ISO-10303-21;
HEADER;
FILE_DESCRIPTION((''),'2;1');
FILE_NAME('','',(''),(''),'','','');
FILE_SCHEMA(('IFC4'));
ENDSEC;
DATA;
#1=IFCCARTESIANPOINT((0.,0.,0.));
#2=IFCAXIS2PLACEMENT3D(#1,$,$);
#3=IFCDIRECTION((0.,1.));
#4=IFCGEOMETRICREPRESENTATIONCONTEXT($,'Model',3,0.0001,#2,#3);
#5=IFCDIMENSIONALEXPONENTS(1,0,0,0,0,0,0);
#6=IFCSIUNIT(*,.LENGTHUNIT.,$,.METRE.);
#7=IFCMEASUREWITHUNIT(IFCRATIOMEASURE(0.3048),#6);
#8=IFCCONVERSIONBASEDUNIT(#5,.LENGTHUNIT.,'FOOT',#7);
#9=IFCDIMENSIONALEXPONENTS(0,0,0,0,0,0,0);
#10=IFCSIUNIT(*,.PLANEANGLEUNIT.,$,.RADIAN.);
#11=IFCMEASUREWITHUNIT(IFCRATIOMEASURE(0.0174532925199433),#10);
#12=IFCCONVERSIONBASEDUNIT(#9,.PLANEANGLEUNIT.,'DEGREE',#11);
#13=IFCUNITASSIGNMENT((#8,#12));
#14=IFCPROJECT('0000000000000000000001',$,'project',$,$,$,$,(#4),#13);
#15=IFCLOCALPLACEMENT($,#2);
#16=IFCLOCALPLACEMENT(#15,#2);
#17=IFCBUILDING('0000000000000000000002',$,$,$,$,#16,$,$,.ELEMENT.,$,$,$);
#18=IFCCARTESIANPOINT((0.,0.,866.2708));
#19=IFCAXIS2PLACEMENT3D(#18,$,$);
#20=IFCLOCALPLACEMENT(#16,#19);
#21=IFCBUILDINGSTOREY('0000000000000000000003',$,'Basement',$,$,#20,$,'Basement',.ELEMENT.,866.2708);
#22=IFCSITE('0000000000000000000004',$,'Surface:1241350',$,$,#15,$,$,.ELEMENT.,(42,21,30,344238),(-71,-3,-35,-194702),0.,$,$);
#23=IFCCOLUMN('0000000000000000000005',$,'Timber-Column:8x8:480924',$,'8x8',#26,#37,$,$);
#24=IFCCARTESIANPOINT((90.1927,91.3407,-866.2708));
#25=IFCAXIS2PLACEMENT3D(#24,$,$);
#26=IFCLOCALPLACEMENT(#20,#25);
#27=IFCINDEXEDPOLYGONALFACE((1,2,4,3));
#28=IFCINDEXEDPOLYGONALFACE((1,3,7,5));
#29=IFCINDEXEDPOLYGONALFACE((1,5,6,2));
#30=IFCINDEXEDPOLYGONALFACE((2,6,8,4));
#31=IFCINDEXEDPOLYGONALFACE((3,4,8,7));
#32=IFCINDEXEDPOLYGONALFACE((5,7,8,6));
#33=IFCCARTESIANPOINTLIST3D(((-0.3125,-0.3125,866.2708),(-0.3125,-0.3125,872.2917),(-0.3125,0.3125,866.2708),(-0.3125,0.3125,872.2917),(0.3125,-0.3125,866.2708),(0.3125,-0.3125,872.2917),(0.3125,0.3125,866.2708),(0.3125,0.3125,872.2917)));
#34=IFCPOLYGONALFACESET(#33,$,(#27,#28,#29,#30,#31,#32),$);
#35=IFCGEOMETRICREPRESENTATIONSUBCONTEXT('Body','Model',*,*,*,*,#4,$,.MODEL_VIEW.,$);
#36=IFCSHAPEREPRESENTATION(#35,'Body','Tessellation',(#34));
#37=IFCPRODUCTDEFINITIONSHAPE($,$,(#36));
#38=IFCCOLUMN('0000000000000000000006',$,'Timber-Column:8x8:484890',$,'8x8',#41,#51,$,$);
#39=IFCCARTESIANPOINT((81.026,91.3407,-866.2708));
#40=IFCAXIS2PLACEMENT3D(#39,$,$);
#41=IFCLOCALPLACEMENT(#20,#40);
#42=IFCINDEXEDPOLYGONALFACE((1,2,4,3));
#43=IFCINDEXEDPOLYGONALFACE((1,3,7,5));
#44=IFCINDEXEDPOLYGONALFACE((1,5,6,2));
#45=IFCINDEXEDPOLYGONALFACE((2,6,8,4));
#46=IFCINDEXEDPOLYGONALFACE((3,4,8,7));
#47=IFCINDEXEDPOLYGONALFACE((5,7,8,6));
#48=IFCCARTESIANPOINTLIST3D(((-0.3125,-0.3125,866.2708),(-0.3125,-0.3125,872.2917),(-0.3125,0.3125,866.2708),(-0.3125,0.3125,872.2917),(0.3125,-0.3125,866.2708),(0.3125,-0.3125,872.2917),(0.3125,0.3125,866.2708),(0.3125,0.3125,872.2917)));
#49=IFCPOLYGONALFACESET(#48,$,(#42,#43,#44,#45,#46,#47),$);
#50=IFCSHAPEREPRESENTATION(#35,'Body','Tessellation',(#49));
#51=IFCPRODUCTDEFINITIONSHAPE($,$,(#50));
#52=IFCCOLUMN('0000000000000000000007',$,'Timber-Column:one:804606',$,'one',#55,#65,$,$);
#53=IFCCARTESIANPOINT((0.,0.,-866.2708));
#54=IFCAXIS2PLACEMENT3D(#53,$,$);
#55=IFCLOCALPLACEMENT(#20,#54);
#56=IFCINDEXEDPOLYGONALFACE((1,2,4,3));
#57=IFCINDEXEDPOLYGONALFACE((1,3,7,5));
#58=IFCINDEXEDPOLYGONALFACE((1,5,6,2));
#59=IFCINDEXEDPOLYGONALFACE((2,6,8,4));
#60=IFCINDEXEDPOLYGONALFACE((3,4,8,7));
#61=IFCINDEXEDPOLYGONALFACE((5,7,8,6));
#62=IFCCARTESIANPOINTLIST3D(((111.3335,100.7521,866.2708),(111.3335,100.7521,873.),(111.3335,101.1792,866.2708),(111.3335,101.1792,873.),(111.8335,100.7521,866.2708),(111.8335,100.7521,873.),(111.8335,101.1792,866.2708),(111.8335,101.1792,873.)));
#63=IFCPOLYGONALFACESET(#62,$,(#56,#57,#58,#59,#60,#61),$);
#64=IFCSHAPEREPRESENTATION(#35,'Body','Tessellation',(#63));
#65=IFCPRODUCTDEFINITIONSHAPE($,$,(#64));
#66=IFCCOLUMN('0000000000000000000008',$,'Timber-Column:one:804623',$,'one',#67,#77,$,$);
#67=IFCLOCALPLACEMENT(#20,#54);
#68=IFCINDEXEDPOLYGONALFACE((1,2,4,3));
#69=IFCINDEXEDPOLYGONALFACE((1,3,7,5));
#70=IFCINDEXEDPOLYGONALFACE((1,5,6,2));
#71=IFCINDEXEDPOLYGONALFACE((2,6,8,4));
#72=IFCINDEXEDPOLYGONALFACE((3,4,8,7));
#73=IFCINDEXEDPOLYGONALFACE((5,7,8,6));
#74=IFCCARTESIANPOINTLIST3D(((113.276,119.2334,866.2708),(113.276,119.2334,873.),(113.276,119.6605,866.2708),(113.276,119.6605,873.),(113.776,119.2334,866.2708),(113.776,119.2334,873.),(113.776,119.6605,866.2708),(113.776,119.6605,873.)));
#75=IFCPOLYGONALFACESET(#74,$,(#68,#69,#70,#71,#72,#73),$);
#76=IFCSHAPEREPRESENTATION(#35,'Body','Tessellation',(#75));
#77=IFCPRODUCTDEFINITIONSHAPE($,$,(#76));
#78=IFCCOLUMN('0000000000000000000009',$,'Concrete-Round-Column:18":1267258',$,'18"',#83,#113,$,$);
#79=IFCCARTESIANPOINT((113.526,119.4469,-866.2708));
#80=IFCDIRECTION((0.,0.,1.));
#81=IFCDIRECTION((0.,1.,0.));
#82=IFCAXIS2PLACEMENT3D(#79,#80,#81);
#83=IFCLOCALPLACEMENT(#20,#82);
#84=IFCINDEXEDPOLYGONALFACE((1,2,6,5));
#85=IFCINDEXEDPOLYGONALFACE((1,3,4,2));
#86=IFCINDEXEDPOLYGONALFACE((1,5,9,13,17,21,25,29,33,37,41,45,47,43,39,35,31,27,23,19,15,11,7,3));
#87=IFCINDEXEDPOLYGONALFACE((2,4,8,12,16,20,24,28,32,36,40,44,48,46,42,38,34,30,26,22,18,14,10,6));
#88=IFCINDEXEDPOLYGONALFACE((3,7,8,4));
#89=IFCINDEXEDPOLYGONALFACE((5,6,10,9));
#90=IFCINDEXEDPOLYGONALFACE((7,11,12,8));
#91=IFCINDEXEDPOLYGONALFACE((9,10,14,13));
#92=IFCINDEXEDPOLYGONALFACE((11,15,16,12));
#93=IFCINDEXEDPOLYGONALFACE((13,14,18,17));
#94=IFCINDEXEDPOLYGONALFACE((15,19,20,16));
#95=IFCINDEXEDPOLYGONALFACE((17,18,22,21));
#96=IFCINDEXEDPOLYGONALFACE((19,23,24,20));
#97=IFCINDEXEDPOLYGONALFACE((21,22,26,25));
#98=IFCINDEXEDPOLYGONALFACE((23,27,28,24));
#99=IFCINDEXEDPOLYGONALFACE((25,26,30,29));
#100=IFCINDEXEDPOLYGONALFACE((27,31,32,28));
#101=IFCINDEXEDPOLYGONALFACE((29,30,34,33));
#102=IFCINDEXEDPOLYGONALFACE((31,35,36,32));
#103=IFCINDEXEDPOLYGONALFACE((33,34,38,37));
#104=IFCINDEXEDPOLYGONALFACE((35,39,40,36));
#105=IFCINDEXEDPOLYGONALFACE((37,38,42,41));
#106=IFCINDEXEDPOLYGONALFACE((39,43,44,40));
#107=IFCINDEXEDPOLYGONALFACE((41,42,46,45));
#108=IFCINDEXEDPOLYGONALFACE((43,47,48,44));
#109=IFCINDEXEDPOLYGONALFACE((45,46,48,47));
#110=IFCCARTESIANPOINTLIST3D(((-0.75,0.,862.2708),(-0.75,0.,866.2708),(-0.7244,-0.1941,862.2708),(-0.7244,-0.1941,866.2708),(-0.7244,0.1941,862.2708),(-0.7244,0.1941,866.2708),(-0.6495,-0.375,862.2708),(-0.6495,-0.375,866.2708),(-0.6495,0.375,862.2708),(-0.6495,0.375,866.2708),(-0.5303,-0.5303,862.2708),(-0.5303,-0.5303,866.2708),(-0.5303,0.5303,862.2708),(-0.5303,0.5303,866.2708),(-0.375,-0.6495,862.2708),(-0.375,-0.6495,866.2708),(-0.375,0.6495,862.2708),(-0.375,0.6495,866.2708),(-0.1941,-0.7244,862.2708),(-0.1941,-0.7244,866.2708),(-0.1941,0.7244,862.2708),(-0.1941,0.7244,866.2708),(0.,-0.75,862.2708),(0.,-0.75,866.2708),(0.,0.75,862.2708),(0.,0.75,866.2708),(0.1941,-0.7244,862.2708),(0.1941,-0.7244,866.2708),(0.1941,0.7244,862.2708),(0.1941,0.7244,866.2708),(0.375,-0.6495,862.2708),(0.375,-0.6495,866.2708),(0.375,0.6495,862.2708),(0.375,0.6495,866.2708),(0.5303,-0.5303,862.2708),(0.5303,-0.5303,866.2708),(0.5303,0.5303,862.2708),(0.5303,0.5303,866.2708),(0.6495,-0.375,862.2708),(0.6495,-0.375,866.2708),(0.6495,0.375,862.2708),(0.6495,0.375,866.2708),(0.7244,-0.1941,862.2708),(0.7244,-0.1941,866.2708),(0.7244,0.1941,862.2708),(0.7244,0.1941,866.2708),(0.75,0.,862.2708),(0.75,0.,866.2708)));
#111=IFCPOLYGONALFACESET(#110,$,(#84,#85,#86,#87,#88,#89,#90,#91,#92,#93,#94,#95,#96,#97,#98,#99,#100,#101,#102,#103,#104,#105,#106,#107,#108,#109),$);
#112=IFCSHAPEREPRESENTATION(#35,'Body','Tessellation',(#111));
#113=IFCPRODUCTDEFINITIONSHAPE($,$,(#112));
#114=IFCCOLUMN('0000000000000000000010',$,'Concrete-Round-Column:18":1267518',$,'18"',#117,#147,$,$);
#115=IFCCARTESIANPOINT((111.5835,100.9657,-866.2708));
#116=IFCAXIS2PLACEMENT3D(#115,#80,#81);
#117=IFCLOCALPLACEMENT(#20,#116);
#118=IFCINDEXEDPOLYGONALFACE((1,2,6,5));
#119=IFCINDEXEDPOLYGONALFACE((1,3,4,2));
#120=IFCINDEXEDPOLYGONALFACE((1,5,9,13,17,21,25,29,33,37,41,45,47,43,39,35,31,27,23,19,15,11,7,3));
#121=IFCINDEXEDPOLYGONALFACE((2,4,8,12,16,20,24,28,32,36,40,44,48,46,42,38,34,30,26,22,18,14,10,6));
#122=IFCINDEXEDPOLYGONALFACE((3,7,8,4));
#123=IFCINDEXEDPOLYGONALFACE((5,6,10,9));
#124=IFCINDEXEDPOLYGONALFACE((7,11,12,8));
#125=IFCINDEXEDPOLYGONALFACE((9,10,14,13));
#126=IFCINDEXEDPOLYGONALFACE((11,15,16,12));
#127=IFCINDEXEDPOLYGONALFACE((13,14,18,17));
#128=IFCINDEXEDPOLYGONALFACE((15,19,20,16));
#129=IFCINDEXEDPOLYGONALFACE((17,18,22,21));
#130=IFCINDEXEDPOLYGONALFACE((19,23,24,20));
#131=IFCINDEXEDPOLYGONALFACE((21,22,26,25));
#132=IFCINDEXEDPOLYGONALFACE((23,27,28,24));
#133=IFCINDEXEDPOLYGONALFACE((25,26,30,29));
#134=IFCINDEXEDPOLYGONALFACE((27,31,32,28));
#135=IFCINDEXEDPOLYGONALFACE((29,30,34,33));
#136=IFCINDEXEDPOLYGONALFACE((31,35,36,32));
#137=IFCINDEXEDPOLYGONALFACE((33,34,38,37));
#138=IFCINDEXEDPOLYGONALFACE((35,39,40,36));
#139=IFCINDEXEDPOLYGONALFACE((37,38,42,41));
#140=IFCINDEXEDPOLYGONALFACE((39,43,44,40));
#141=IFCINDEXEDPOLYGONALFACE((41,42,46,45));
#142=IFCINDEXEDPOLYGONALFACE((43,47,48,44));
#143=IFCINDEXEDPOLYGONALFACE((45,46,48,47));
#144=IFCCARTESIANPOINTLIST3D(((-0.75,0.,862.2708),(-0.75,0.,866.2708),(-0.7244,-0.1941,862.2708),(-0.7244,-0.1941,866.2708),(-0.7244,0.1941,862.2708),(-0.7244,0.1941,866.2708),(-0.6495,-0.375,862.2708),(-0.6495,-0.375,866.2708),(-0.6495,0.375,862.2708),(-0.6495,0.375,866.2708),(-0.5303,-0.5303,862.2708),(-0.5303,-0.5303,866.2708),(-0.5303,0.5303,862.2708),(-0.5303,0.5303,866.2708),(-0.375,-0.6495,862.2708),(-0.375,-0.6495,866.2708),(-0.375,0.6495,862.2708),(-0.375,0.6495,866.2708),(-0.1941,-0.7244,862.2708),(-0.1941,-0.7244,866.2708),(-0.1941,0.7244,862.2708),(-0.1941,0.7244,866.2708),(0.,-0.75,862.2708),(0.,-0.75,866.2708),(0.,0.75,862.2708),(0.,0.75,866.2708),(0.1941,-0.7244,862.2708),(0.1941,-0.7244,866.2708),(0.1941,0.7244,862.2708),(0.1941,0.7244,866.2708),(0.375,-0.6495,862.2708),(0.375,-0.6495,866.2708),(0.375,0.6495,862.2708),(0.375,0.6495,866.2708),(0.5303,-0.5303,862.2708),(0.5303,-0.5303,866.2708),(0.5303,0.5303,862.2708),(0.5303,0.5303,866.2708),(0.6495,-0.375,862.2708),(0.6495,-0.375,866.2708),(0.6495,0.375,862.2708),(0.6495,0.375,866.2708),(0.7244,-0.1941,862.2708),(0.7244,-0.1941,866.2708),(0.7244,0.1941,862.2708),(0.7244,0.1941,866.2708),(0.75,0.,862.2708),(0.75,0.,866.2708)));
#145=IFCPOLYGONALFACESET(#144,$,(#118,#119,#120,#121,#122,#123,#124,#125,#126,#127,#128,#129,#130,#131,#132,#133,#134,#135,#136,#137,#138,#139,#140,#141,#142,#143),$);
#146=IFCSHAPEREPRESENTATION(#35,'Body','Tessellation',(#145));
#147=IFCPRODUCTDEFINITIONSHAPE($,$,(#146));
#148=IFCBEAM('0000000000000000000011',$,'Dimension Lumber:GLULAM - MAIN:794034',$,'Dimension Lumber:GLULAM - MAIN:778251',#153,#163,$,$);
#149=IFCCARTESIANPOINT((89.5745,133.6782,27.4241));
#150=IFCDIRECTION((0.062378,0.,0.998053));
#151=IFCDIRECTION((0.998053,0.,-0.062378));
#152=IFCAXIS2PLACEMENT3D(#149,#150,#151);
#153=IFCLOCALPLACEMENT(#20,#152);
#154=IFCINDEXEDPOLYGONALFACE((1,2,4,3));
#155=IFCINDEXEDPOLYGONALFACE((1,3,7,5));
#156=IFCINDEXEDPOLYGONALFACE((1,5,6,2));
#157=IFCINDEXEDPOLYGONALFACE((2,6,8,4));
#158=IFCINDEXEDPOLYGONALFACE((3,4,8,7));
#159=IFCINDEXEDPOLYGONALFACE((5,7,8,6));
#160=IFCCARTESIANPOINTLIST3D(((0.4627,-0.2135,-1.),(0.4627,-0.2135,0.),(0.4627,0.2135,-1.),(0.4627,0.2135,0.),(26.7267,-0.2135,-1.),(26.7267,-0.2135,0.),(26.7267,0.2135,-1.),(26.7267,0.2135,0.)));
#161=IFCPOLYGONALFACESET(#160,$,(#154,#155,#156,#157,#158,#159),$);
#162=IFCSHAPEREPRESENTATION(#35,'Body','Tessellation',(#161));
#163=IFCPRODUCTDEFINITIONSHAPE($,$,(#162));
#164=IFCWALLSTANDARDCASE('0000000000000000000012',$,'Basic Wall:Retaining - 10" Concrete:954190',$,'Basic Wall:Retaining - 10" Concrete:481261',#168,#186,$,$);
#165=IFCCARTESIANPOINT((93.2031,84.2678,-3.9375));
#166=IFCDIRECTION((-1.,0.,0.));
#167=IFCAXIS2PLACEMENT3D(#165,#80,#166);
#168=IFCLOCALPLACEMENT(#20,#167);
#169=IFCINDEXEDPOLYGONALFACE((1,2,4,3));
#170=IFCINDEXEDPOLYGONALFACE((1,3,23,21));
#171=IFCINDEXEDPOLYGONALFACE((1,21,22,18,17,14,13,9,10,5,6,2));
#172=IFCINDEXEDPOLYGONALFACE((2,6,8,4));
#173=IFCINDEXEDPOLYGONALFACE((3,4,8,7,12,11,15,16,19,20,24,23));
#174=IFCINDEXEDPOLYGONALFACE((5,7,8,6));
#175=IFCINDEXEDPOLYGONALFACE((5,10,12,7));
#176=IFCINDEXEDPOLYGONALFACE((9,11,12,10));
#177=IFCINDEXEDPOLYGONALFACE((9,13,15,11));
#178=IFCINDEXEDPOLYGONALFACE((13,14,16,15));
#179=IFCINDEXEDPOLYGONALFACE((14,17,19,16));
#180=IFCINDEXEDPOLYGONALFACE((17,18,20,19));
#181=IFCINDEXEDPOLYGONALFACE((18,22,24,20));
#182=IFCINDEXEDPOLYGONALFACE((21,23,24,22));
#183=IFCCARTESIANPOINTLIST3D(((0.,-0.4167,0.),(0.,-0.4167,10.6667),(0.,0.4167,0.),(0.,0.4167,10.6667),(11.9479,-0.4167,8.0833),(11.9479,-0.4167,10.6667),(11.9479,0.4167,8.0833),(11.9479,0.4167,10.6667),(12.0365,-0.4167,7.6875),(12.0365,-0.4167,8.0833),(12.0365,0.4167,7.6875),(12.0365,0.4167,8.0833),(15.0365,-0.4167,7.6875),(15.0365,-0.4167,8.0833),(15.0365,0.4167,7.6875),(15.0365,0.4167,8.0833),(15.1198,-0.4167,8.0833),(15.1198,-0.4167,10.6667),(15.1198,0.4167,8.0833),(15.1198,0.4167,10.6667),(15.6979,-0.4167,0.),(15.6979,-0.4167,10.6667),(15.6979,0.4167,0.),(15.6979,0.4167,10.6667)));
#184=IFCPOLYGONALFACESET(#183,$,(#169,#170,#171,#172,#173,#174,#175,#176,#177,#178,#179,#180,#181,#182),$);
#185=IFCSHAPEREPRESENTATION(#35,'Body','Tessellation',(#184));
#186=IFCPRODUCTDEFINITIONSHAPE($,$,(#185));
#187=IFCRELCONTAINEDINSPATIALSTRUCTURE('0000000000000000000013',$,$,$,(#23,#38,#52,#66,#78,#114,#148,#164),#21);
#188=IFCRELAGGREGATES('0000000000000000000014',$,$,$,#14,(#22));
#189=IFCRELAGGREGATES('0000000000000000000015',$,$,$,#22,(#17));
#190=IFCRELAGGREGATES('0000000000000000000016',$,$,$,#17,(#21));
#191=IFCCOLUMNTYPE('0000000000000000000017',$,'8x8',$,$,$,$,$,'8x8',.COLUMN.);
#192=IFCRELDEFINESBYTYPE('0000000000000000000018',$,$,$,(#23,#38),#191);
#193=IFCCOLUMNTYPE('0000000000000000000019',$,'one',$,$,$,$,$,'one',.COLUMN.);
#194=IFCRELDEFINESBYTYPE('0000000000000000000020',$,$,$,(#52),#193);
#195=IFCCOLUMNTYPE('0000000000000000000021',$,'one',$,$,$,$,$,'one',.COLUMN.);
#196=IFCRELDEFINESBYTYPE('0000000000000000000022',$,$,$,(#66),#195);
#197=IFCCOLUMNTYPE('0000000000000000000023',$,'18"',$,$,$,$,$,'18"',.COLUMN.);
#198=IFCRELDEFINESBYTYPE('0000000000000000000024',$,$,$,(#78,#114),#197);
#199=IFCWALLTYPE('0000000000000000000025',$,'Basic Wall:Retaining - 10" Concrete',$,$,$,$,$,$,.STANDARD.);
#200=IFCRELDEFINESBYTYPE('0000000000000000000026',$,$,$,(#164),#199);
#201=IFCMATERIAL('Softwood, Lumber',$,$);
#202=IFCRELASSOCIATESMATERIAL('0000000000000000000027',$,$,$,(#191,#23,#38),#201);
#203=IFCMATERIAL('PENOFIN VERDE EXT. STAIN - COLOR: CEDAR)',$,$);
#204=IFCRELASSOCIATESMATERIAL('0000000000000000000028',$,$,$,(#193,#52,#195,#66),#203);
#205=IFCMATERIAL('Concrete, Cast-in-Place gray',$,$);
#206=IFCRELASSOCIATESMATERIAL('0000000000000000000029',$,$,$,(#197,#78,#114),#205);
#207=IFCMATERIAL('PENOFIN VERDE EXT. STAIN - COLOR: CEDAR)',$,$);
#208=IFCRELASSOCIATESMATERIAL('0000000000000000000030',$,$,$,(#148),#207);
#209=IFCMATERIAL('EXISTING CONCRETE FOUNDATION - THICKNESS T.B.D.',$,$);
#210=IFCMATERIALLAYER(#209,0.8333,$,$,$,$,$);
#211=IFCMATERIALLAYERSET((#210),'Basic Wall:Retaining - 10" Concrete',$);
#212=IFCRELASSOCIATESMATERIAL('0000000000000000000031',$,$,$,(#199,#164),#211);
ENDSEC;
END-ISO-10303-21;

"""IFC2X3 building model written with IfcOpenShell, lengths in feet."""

from ifc_helpers import new_model, entity, si_unit, converted_unit, direction, frame, frame_2d, origin, origin_2d_with_axis, place, context, subcontext, project, spatial, rectangle, circle, extrude, source, transform, mapped, material, layer, layer_set, layer_usage, type_object, type_shapes, element, save


model = new_model("IFC2X3")

# Units and contexts
model_context = context("Model", 3, precision=0.0001, world=origin(), true_north=direction((0.0, 1.0)))
body_context = subcontext(model_context, "Body", "Model", "MODEL_VIEW")
ifc_project = project(units=[converted_unit("LENGTHUNIT", "FOOT", entity("IfcRatioMeasure", 0.3048), si_unit("LENGTHUNIT", "METRE"), dimensions=[1, 0, 0, 0, 0, 0, 0]), converted_unit("PLANEANGLEUNIT", "DEGREE", entity("IfcRatioMeasure", 0.0174532925199433), si_unit("PLANEANGLEUNIT", "RADIAN"), dimensions=[0, 0, 0, 0, 0, 0, 0])], contexts=[model_context])

# Site, building, storey
site_placement = place(None, origin())
site = spatial("IfcSite", under=ifc_project, at=site_placement, Name="Surface:1241350", CompositionType="ELEMENT", RefLatitude=(42, 21, 30, 344238), RefLongitude=(-71, -3, -35, -194702), RefElevation=0.0)
building_placement = place(site_placement, origin())
building = spatial("IfcBuilding", under=site, at=building_placement, CompositionType="ELEMENT")
storey_placement = place(building_placement, frame((0.0, 0.0, 866.2708)))
storey = spatial("IfcBuildingStorey", under=building, at=storey_placement, Name="Basement", LongName="Basement", CompositionType="ELEMENT", Elevation=866.2708)

# Shared definitions
ifc_material_1 = material(Name="EXISTING CONCRETE FOUNDATION - THICKNESS T.B.D.")

# Columns
ifc_material_2 = material(Name="Softwood, Lumber")
column_type_1 = type_object("IfcColumnType", Name="8x8", ElementType="8x8", PredefinedType="COLUMN", material=ifc_material_2)
shared_shape_1 = source(origin(), body_context, "Body", "SweptSolid", [
    extrude(rectangle(XDim=0.625, YDim=0.625, at=origin_2d_with_axis()), frame((0.0, 0.0, 866.2708), z_axis=(0.0, 0.0, 1.0), x_axis=(0.0, -1.0, 0.0)), (0.0, 0.0, 1.0), 6.0208),
])
type_shapes(column_type_1, [shared_shape_1])
for number, where, name in (
    (1, (90.1927, 91.3407, -866.2708), "Timber-Column:8x8:480924"),
    (2, (81.026, 91.3407, -866.2708), "Timber-Column:8x8:484890"),
):
    element("IfcColumn", number, at=place(storey_placement, frame(where)), inside=storey, type_object=column_type_1, material=ifc_material_2, Name=name, ObjectType="8x8", context=body_context, shape_type="MappedRepresentation", body=[
        mapped(shared_shape_1, transform((0.0, 0.0, 0.0), scale=1.0)),
    ])
ifc_material_3 = material(Name="PENOFIN VERDE EXT. STAIN - COLOR: CEDAR)")
column_type_2 = type_object("IfcColumnType", Name="one", ElementType="one", PredefinedType="COLUMN", material=ifc_material_3)
shared_shape_2 = source(origin(), body_context, "Body", "SweptSolid", [
    extrude(rectangle(XDim=0.4271, YDim=0.5, at=frame_2d((0.0, 0.0), x_axis=(1.0, 0.0))), frame((111.5835, 100.9657, 866.2708), z_axis=(0.0, 0.0, 1.0), x_axis=(0.0, -1.0, 0.0)), (0.0, 0.0, 1.0), 6.7292),
])
type_shapes(column_type_2, [shared_shape_2])
column_1_placement = place(storey_placement, frame((0.0, 0.0, -866.2708)))
element("IfcColumn", 3, at=column_1_placement, inside=storey, type_object=column_type_2, material=ifc_material_3, Name="Timber-Column:one:804606", ObjectType="one", context=body_context, shape_type="MappedRepresentation", body=[
    mapped(shared_shape_2, transform((0.0, 0.0, 0.0), scale=1.0)),
])
column_type_3 = type_object("IfcColumnType", Name="one", ElementType="one", PredefinedType="COLUMN", material=ifc_material_3)
shared_shape_3 = source(origin(), body_context, "Body", "SweptSolid", [
    extrude(rectangle(XDim=0.4271, YDim=0.5, at=frame_2d((0.0, 0.0), x_axis=(1.0, 0.0))), frame((113.526, 119.4469, 866.2708), z_axis=(0.0, 0.0, 1.0), x_axis=(0.0, -1.0, 0.0)), (0.0, 0.0, 1.0), 6.7292),
])
type_shapes(column_type_3, [shared_shape_3])
column_2_placement = place(storey_placement, frame((0.0, 0.0, -866.2708)))
element("IfcColumn", 4, at=column_2_placement, inside=storey, type_object=column_type_3, material=ifc_material_3, Name="Timber-Column:one:804623", ObjectType="one", context=body_context, shape_type="MappedRepresentation", body=[
    mapped(shared_shape_3, transform((0.0, 0.0, 0.0), scale=1.0)),
])
ifc_material_4 = material(Name="Concrete, Cast-in-Place gray")
column_type_4 = type_object("IfcColumnType", Name="18\"", ElementType="18\"", PredefinedType="COLUMN", material=ifc_material_4)
shared_shape_4 = source(origin(), body_context, "Body", "SweptSolid", [
    extrude(circle(Radius=0.75, at=frame_2d((0.0, 0.0), x_axis=(1.0, 0.0))), frame((0.0, 0.0, 862.2708)), (0.0, 0.0, 1.0), 4.0),
])
type_shapes(column_type_4, [shared_shape_4])
for number, where, z_axis, x_axis, name in (
    (5, (113.526, 119.4469, -866.2708), (0.0, 0.0, 1.0), (0.0, 1.0, 0.0), "Concrete-Round-Column:18\":1267258"),
    (6, (111.5835, 100.9657, -866.2708), (0.0, 0.0, 1.0), (0.0, 1.0, 0.0), "Concrete-Round-Column:18\":1267518"),
):
    element("IfcColumn", number, at=place(storey_placement, frame(where, z_axis=z_axis, x_axis=x_axis)), inside=storey, type_object=column_type_4, material=ifc_material_4, Name=name, ObjectType="18\"", context=body_context, shape_type="MappedRepresentation", body=[
        mapped(shared_shape_4, transform((0.0, 0.0, 0.0), scale=1.0)),
    ])

# Beam
ifc_material_5 = material(Name="PENOFIN VERDE EXT. STAIN - COLOR: CEDAR)")
beam_1_placement = place(storey_placement, frame((89.5745, 133.6782, 27.4241), z_axis=(0.062378, 0.0, 0.998053), x_axis=(0.998053, 0.0, -0.062378)))
element("IfcBeam", 7, at=beam_1_placement, inside=storey, material=ifc_material_5, Name="Dimension Lumber:GLULAM - MAIN:794034", ObjectType="Dimension Lumber:GLULAM - MAIN:778251", context=body_context, shape_type="SweptSolid", body=[
    extrude(rectangle(XDim=1.0, YDim=0.4271, at=frame_2d((0.0, 0.0), x_axis=(1.0, 0.0))), frame((0.4627, 0.0, -0.5), z_axis=(1.0, 0.0, 0.0), x_axis=(0.0, 0.0, -1.0)), (0.0, 0.0, 1.0), 26.264),
])

# Wall, openings
ifc_layer_1 = layer(ifc_material_1, 0.8333)
ifc_layer_set_1 = layer_set([ifc_layer_1], Name="Basic Wall:Retaining - 10\" Concrete")
ifc_layer_usage_1 = layer_usage(ifc_layer_set_1, "AXIS2", "NEGATIVE", 0.4167)
wall_type_1 = type_object("IfcWallType", Name="Basic Wall:Retaining - 10\" Concrete", PredefinedType="STANDARD", material=ifc_layer_set_1)
wall_1_placement = place(storey_placement, frame((93.2031, 84.2678, -3.9375), z_axis=(0.0, 0.0, 1.0), x_axis=(-1.0, 0.0, 0.0)))
wall_1 = element("IfcWallStandardCase", 8, at=wall_1_placement, inside=storey, type_object=wall_type_1, material=ifc_layer_usage_1, Name="Basic Wall:Retaining - 10\" Concrete:954190", ObjectType="Basic Wall:Retaining - 10\" Concrete:481261", context=body_context, shape_type="SweptSolid", body=[
    extrude(rectangle(XDim=15.6979, YDim=0.8333, at=frame_2d((7.849, 0.0), x_axis=(-1.0, 0.0))), origin(), (0.0, 0.0, 1.0), 10.6667),
])
opening_1_placement = place(wall_1_placement, origin())
element("IfcOpeningElement", 9, at=opening_1_placement, cuts=wall_1, ObjectType="Opening", context=body_context, shape_type="SweptSolid", body=[
    extrude(rectangle(XDim=7.6875, YDim=3.0, at=frame_2d((0.0, 0.0), x_axis=(0.0, 1.0))), frame((13.5365, -5.0521, 11.5312), z_axis=(0.0, 1.0, 0.0), x_axis=(-1.0, 0.0, 0.0)), (0.0, 0.0, 1.0), 10.0),
])
opening_2_placement = place(wall_1_placement, origin())
element("IfcOpeningElement", 10, at=opening_2_placement, cuts=wall_1, ObjectType="Opening", context=body_context, shape_type="SweptSolid", body=[
    extrude(rectangle(XDim=2.5833, YDim=3.1719, at=frame_2d((0.0, 0.0), x_axis=(0.0, 1.0))), frame((13.5339, 0.4167, 9.375), z_axis=(0.0, -1.0, 0.0), x_axis=(-1.0, 0.0, 0.0)), (0.0, 0.0, 1.0), 0.8333),
])

save(model, "model.ifc")
